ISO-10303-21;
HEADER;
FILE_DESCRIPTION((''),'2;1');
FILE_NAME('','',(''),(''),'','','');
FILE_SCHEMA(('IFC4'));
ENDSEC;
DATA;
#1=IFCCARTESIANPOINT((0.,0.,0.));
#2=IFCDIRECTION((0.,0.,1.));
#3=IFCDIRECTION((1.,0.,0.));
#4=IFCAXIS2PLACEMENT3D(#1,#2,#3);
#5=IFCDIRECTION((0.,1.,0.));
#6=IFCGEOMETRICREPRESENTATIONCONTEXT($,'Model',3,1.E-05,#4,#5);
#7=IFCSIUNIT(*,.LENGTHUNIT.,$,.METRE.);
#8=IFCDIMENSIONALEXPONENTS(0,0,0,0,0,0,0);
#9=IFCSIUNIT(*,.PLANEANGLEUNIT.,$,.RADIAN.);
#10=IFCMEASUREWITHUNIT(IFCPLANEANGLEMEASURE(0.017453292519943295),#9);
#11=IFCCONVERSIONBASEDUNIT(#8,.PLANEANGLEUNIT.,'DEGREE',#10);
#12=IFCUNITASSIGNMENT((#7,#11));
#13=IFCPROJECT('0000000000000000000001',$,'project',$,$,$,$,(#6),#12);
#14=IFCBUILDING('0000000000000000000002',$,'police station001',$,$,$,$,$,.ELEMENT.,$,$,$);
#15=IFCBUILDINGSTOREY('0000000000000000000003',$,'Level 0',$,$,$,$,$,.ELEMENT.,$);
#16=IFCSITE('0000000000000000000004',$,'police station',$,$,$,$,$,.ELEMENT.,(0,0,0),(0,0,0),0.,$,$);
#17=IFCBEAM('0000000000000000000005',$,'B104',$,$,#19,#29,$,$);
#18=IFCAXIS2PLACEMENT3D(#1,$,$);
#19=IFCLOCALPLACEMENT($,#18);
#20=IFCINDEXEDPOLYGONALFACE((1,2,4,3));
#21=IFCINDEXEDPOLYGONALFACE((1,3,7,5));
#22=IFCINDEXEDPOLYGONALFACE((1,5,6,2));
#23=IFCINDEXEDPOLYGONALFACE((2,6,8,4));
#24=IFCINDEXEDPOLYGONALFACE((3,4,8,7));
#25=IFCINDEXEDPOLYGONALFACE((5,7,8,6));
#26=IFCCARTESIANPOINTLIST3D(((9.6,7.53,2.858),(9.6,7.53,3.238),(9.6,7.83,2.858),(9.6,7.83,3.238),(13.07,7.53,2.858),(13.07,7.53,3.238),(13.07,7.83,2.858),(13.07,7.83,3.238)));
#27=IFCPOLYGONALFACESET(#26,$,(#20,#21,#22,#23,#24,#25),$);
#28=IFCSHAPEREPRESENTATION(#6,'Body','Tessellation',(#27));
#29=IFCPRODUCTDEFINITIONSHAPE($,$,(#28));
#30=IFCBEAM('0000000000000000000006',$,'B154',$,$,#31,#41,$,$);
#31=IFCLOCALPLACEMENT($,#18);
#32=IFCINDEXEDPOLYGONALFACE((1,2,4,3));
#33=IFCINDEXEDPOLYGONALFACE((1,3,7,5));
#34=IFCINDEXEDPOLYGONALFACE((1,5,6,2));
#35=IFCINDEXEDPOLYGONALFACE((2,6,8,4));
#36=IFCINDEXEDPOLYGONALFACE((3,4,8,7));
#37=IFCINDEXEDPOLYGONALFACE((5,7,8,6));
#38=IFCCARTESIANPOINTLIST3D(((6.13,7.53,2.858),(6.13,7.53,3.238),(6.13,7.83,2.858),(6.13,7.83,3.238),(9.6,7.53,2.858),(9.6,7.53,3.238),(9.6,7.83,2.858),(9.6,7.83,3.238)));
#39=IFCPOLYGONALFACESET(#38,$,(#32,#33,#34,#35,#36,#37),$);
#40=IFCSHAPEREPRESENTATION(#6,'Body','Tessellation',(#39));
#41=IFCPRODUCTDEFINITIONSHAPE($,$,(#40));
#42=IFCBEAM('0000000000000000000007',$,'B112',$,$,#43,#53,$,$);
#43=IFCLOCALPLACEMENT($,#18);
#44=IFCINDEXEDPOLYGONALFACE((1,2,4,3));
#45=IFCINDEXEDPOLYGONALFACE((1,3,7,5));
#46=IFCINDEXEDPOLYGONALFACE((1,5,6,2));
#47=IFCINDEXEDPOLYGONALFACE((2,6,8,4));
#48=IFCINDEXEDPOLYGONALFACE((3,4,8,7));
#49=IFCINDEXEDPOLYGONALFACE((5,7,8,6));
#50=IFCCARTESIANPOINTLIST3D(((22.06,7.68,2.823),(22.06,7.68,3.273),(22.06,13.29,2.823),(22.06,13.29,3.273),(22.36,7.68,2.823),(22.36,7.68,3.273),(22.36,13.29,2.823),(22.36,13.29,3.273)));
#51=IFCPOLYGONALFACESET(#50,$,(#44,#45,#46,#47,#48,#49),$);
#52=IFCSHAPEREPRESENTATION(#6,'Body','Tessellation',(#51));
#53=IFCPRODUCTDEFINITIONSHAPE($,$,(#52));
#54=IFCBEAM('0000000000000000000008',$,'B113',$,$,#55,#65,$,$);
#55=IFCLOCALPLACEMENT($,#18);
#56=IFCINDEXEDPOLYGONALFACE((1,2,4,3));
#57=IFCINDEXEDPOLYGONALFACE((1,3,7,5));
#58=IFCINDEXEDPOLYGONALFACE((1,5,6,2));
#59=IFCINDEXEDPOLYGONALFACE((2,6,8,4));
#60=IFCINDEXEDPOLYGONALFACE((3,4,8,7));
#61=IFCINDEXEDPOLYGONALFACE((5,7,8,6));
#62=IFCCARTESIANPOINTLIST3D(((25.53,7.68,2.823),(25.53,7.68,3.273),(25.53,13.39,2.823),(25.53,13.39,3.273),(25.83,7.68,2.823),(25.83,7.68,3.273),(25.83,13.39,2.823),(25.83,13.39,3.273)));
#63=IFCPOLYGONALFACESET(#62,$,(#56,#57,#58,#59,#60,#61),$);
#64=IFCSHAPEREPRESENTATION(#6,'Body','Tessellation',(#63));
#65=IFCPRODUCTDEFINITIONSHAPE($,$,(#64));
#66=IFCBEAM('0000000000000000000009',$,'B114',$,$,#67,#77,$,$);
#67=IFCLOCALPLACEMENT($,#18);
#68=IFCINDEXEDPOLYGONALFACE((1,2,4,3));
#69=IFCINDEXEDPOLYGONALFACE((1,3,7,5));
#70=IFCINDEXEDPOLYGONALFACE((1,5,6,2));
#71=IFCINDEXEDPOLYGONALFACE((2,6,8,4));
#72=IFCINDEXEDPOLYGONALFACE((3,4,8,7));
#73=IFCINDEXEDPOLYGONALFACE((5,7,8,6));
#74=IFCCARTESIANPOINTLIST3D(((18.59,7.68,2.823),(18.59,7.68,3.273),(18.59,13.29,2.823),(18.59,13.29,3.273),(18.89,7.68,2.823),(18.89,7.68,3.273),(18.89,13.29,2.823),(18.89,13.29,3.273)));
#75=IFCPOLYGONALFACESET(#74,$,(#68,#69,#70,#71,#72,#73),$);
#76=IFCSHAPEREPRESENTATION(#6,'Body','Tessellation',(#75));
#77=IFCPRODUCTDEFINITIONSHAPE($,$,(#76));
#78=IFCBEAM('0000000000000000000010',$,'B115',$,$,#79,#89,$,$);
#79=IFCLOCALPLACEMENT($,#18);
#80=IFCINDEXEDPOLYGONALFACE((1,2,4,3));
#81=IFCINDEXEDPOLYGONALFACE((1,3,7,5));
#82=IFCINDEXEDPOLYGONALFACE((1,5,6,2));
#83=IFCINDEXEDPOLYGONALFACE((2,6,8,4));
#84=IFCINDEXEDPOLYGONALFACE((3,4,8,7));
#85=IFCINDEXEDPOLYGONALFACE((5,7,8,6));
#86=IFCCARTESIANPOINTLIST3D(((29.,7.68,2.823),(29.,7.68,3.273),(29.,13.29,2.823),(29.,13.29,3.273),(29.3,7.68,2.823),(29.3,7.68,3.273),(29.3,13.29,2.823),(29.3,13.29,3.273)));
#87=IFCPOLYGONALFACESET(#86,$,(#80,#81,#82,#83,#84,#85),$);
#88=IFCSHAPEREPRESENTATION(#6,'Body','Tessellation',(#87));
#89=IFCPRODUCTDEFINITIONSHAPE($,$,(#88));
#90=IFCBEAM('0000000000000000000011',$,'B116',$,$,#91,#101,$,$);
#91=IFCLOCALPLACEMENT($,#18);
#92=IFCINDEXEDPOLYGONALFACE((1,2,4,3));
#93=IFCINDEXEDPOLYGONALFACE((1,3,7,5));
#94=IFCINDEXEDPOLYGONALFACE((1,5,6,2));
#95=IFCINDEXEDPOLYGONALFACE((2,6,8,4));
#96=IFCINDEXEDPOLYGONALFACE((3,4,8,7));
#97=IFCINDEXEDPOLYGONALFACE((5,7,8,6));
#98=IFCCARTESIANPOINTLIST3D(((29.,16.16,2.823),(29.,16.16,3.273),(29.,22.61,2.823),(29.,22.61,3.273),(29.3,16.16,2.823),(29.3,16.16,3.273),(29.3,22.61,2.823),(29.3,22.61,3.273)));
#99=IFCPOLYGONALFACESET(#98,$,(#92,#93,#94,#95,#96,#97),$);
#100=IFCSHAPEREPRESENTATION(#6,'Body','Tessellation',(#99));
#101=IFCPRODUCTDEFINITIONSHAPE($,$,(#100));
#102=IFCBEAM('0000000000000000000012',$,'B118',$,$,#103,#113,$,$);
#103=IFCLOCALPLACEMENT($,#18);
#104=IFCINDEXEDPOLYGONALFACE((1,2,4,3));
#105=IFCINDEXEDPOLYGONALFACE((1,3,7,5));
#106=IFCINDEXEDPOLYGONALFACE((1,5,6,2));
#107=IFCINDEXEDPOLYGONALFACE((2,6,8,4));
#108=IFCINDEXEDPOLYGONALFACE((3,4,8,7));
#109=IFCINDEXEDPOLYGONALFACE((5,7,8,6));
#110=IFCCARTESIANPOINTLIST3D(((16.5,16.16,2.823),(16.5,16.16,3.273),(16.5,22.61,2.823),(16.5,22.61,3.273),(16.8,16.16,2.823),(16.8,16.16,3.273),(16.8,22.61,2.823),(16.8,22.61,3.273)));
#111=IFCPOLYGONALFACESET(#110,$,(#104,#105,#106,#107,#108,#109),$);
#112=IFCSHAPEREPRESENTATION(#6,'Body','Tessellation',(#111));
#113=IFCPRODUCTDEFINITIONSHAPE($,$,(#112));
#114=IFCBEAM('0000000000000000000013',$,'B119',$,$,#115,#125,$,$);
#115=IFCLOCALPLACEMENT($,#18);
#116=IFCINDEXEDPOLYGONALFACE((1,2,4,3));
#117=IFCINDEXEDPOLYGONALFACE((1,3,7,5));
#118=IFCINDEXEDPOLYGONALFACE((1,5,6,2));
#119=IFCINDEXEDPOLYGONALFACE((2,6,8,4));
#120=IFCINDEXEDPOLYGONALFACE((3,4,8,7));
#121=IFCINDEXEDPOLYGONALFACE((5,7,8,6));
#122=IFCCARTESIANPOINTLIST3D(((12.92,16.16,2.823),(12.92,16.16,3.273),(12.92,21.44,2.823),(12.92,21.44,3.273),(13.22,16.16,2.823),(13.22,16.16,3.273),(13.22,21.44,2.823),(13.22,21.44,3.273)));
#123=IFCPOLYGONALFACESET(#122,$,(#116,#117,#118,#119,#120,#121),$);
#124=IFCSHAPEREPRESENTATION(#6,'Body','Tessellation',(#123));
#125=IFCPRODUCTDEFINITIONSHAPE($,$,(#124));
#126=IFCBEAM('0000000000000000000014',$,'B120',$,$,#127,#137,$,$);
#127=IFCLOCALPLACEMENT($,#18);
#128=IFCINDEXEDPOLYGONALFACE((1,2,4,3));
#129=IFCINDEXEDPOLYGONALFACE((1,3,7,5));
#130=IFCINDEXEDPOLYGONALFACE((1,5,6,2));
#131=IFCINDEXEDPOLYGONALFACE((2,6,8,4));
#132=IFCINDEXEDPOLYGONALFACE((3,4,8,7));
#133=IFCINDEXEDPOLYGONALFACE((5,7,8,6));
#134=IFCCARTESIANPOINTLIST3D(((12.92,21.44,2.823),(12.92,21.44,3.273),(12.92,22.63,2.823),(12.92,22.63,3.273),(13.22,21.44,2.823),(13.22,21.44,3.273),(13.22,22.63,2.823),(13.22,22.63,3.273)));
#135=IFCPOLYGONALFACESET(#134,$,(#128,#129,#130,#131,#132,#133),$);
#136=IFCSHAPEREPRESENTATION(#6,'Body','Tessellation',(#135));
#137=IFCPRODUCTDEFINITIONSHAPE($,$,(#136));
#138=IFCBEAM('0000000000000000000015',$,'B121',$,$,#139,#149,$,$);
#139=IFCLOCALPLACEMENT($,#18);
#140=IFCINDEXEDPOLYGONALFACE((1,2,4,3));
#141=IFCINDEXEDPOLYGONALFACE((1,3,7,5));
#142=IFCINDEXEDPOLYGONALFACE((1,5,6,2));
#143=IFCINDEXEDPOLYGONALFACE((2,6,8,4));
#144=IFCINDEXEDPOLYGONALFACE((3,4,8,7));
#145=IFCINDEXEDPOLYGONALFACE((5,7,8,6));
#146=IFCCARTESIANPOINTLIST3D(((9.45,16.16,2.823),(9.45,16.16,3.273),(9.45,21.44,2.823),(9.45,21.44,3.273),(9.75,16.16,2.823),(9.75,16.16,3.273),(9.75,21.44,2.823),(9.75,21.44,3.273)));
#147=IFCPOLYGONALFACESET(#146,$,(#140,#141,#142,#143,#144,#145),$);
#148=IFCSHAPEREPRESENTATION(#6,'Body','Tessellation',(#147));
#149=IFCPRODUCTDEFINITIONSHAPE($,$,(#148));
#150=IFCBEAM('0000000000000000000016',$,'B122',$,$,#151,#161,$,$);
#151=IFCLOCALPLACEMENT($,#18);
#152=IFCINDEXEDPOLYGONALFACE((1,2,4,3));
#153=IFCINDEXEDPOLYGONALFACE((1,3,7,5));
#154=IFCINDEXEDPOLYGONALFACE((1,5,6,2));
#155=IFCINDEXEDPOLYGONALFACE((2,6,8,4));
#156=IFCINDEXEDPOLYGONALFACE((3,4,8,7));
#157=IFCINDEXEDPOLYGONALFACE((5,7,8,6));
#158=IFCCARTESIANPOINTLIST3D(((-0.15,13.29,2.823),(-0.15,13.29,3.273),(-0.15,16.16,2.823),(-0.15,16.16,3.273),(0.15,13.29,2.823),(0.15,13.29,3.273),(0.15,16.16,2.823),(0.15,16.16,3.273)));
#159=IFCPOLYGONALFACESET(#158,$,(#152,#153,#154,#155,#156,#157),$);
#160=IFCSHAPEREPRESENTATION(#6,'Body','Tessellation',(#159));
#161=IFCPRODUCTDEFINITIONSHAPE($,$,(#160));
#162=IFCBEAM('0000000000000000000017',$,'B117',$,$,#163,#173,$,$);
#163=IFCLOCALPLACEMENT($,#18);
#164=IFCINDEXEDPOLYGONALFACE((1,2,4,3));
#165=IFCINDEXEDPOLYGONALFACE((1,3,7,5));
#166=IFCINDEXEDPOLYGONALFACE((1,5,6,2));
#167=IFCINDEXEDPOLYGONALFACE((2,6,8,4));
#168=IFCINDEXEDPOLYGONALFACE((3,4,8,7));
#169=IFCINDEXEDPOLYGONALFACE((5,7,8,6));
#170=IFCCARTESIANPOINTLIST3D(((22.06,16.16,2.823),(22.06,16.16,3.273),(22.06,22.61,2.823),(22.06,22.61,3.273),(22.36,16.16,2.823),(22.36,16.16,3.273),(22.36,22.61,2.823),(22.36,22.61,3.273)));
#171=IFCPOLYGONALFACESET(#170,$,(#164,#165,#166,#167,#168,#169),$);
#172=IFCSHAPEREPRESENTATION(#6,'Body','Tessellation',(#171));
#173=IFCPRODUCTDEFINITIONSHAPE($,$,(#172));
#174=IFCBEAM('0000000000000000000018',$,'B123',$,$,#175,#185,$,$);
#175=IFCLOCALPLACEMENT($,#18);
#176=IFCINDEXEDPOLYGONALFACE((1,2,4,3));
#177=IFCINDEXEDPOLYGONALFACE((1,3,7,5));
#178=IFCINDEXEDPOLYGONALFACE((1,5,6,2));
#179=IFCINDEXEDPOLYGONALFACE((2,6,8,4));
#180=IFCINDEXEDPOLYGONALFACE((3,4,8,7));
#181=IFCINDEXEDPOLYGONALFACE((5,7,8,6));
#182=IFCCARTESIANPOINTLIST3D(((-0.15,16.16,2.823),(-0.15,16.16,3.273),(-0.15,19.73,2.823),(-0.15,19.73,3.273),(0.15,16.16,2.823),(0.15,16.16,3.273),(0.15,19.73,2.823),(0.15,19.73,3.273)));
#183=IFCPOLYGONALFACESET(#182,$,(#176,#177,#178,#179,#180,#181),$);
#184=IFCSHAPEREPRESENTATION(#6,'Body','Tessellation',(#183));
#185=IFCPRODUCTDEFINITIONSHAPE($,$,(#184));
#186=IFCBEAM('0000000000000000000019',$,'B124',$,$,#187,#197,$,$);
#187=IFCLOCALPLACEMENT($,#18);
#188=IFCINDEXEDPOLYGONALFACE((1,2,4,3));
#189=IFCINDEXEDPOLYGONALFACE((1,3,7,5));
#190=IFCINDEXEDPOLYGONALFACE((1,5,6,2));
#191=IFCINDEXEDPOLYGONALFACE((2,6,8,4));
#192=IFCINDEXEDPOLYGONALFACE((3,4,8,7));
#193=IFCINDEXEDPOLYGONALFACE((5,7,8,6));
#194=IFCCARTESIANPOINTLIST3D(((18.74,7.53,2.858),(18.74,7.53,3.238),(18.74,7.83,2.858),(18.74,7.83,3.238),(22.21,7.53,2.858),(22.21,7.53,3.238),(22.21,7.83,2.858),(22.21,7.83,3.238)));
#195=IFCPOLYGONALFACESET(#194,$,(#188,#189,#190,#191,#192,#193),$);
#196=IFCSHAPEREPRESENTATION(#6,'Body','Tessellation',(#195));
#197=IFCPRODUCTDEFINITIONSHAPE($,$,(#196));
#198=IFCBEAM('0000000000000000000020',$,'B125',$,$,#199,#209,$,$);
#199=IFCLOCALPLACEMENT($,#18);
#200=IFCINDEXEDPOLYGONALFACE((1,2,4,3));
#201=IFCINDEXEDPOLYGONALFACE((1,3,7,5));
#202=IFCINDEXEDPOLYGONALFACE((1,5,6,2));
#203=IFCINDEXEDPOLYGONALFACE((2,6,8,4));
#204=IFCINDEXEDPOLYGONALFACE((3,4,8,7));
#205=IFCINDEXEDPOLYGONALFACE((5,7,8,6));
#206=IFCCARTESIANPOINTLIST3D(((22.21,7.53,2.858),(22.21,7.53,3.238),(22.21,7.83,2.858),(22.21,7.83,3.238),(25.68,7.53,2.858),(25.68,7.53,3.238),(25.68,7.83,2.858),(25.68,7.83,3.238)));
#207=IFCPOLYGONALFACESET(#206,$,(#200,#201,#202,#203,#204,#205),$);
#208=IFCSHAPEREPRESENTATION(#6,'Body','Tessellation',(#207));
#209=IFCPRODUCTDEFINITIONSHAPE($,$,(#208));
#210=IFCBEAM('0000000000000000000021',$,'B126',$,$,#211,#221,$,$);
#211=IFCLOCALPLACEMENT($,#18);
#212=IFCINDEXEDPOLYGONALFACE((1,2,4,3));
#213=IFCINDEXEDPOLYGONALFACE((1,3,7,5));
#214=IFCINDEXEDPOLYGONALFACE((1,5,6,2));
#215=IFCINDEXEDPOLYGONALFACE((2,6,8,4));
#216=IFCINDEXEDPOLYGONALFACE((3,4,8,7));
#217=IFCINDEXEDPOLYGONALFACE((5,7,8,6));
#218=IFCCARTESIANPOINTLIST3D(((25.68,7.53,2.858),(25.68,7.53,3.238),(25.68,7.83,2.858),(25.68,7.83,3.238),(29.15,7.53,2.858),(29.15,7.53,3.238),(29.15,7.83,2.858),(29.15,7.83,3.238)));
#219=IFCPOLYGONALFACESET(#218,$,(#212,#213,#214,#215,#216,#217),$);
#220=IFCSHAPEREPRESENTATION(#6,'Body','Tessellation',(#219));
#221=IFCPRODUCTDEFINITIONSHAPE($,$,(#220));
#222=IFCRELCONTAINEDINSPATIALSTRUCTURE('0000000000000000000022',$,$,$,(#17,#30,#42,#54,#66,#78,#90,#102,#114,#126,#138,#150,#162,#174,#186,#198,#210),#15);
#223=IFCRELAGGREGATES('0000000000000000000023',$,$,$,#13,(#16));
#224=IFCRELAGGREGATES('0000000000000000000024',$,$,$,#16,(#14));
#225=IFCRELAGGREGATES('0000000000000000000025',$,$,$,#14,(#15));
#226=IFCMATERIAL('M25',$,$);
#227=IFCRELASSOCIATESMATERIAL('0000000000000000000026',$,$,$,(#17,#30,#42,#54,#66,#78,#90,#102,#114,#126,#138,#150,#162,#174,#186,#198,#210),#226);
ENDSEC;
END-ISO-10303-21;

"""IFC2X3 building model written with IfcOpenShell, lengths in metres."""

from ifc_helpers import new_model, entity, si_unit, converted_unit, direction, frame, frame_2d, origin_with_axes, place, context, project, spatial, rectangle, extrude, material, element, save


model = new_model("IFC2X3")

# Units and contexts
model_context = context("Model", 3, precision=1e-05, world=origin_with_axes(), true_north=direction((0.0, 1.0, 0.0)))
ifc_project = project(units=[si_unit("LENGTHUNIT", "METRE"), converted_unit("PLANEANGLEUNIT", "DEGREE", entity("IfcPlaneAngleMeasure", 0.017453292519943295), si_unit("PLANEANGLEUNIT", "RADIAN"), dimensions=[0, 0, 0, 0, 0, 0, 0])], contexts=[model_context])

# Site, building, storey
site = spatial("IfcSite", under=ifc_project, Name="police station", CompositionType="ELEMENT", RefLatitude=(0, 0, 0), RefLongitude=(0, 0, 0), RefElevation=0.0)
building = spatial("IfcBuilding", under=site, Name="police station001", CompositionType="ELEMENT")
storey = spatial("IfcBuildingStorey", under=building, Name="Level 0", CompositionType="ELEMENT")

# Beams
ifc_material = material(Name="M25")
placement = place(None, origin_with_axes())
element("IfcBeam", 1, at=placement, inside=storey, material=ifc_material, Name="B104", context=model_context, shape_type="SweptSolid", body=[
    extrude(rectangle(XDim=0.3, YDim=0.38, at=frame_2d((0.0, 0.0), x_axis=(0.0, 1.0, 0.0))), frame((9.6, 7.68, 3.048), z_axis=(1.0, 0.0, 0.0), x_axis=(0.0, 0.0, -1.0)), (0.0, 0.0, 1.0), 3.47),
])
element("IfcBeam", 2, at=placement, inside=storey, material=ifc_material, Name="B154", context=model_context, shape_type="SweptSolid", body=[
    extrude(rectangle(XDim=0.3, YDim=0.38, at=frame_2d((0.0, 0.0), x_axis=(0.0, 1.0, 0.0))), frame((6.13, 7.68, 3.048), z_axis=(1.0, 0.0, 0.0), x_axis=(0.0, 0.0, -1.0)), (0.0, 0.0, 1.0), 3.47),
])
element("IfcBeam", 3, at=placement, inside=storey, material=ifc_material, Name="B112", context=model_context, shape_type="SweptSolid", body=[
    extrude(rectangle(XDim=0.3, YDim=0.45, at=frame_2d((0.0, 0.0), x_axis=(0.0, 1.0, 0.0))), frame((22.21, 7.68, 3.048), z_axis=(0.0, 1.0, 0.0), x_axis=(0.0, 0.0, -1.0)), (0.0, 0.0, 1.0), 5.61),
])
element("IfcBeam", 4, at=placement, inside=storey, material=ifc_material, Name="B113", context=model_context, shape_type="SweptSolid", body=[
    extrude(rectangle(XDim=0.3, YDim=0.45, at=frame_2d((0.0, 0.0), x_axis=(0.0, 1.0, 0.0))), frame((25.68, 7.68, 3.048), z_axis=(0.0, 1.0, 0.0), x_axis=(0.0, 0.0, -1.0)), (0.0, 0.0, 1.0), 5.71),
])
element("IfcBeam", 5, at=placement, inside=storey, material=ifc_material, Name="B114", context=model_context, shape_type="SweptSolid", body=[
    extrude(rectangle(XDim=0.3, YDim=0.45, at=frame_2d((0.0, 0.0), x_axis=(0.0, 1.0, 0.0))), frame((18.74, 13.29, 3.048), z_axis=(0.0, -1.0, 0.0), x_axis=(0.0, 0.0, -1.0)), (0.0, 0.0, 1.0), 5.61),
])
element("IfcBeam", 6, at=placement, inside=storey, material=ifc_material, Name="B115", context=model_context, shape_type="SweptSolid", body=[
    extrude(rectangle(XDim=0.3, YDim=0.45, at=frame_2d((0.0, 0.0), x_axis=(0.0, 1.0, 0.0))), frame((29.15, 13.29, 3.048), z_axis=(0.0, -1.0, 0.0), x_axis=(0.0, 0.0, -1.0)), (0.0, 0.0, 1.0), 5.61),
])
element("IfcBeam", 7, at=placement, inside=storey, material=ifc_material, Name="B116", context=model_context, shape_type="SweptSolid", body=[
    extrude(rectangle(XDim=0.3, YDim=0.45, at=frame_2d((0.0, 0.0), x_axis=(0.0, 1.0, 0.0))), frame((29.15, 16.16, 3.048), z_axis=(0.0, 1.0, 0.0), x_axis=(0.0, 0.0, -1.0)), (0.0, 0.0, 1.0), 6.45),
])
element("IfcBeam", 8, at=placement, inside=storey, material=ifc_material, Name="B118", context=model_context, shape_type="SweptSolid", body=[
    extrude(rectangle(XDim=0.3, YDim=0.45, at=frame_2d((0.0, 0.0), x_axis=(0.0, 1.0, 0.0))), frame((16.65, 16.16, 3.048), z_axis=(0.0, 1.0, 0.0), x_axis=(0.0, 0.0, -1.0)), (0.0, 0.0, 1.0), 6.45),
])
element("IfcBeam", 9, at=placement, inside=storey, material=ifc_material, Name="B119", context=model_context, shape_type="SweptSolid", body=[
    extrude(rectangle(XDim=0.3, YDim=0.45, at=frame_2d((0.0, 0.0), x_axis=(0.0, 1.0, 0.0))), frame((13.07, 16.16, 3.048), z_axis=(0.0, 1.0, 0.0), x_axis=(0.0, 0.0, -1.0)), (0.0, 0.0, 1.0), 5.28),
])
element("IfcBeam", 10, at=placement, inside=storey, material=ifc_material, Name="B120", context=model_context, shape_type="SweptSolid", body=[
    extrude(rectangle(XDim=0.3, YDim=0.45, at=frame_2d((0.0, 0.0), x_axis=(0.0, 1.0, 0.0))), frame((13.07, 21.44, 3.048), z_axis=(0.0, 1.0, 0.0), x_axis=(0.0, 0.0, -1.0)), (0.0, 0.0, 1.0), 1.19),
])
element("IfcBeam", 11, at=placement, inside=storey, material=ifc_material, Name="B121", context=model_context, shape_type="SweptSolid", body=[
    extrude(rectangle(XDim=0.3, YDim=0.45, at=frame_2d((0.0, 0.0), x_axis=(0.0, 1.0, 0.0))), frame((9.6, 16.16, 3.048), z_axis=(0.0, 1.0, 0.0), x_axis=(0.0, 0.0, -1.0)), (0.0, 0.0, 1.0), 5.28),
])
element("IfcBeam", 12, at=placement, inside=storey, material=ifc_material, Name="B122", context=model_context, shape_type="SweptSolid", body=[
    extrude(rectangle(XDim=0.3, YDim=0.45, at=frame_2d((0.0, 0.0), x_axis=(0.0, 1.0, 0.0))), frame((0.0, 13.29, 3.048), z_axis=(0.0, 1.0, 0.0), x_axis=(0.0, 0.0, -1.0)), (0.0, 0.0, 1.0), 2.87),
])
element("IfcBeam", 13, at=placement, inside=storey, material=ifc_material, Name="B117", context=model_context, shape_type="SweptSolid", body=[
    extrude(rectangle(XDim=0.3, YDim=0.45, at=frame_2d((0.0, 0.0), x_axis=(0.0, 1.0, 0.0))), frame((22.21, 16.16, 3.048), z_axis=(0.0, 1.0, 0.0), x_axis=(0.0, 0.0, -1.0)), (0.0, 0.0, 1.0), 6.45),
])
element("IfcBeam", 14, at=placement, inside=storey, material=ifc_material, Name="B123", context=model_context, shape_type="SweptSolid", body=[
    extrude(rectangle(XDim=0.3, YDim=0.45, at=frame_2d((0.0, 0.0), x_axis=(0.0, 1.0, 0.0))), frame((0.0, 19.73, 3.048), z_axis=(0.0, -1.0, 0.0), x_axis=(0.0, 0.0, -1.0)), (0.0, 0.0, 1.0), 3.57),
])
element("IfcBeam", 15, at=placement, inside=storey, material=ifc_material, Name="B124", context=model_context, shape_type="SweptSolid", body=[
    extrude(rectangle(XDim=0.3, YDim=0.38, at=frame_2d((0.0, 0.0), x_axis=(0.0, 1.0, 0.0))), frame((18.74, 7.68, 3.048), z_axis=(1.0, 0.0, 0.0), x_axis=(0.0, 0.0, -1.0)), (0.0, 0.0, 1.0), 3.47),
])
element("IfcBeam", 16, at=placement, inside=storey, material=ifc_material, Name="B125", context=model_context, shape_type="SweptSolid", body=[
    extrude(rectangle(XDim=0.3, YDim=0.38, at=frame_2d((0.0, 0.0), x_axis=(0.0, 1.0, 0.0))), frame((25.68, 7.68, 3.048), z_axis=(-1.0, 0.0, 0.0), x_axis=(0.0, 0.0, -1.0)), (0.0, 0.0, 1.0), 3.47),
])
element("IfcBeam", 17, at=placement, inside=storey, material=ifc_material, Name="B126", context=model_context, shape_type="SweptSolid", body=[
    extrude(rectangle(XDim=0.3, YDim=0.38, at=frame_2d((0.0, 0.0), x_axis=(0.0, 1.0, 0.0))), frame((25.68, 7.68, 3.048), z_axis=(1.0, 0.0, 0.0), x_axis=(0.0, 0.0, -1.0)), (0.0, 0.0, 1.0), 3.47),
])

save(model, "model.ifc")
